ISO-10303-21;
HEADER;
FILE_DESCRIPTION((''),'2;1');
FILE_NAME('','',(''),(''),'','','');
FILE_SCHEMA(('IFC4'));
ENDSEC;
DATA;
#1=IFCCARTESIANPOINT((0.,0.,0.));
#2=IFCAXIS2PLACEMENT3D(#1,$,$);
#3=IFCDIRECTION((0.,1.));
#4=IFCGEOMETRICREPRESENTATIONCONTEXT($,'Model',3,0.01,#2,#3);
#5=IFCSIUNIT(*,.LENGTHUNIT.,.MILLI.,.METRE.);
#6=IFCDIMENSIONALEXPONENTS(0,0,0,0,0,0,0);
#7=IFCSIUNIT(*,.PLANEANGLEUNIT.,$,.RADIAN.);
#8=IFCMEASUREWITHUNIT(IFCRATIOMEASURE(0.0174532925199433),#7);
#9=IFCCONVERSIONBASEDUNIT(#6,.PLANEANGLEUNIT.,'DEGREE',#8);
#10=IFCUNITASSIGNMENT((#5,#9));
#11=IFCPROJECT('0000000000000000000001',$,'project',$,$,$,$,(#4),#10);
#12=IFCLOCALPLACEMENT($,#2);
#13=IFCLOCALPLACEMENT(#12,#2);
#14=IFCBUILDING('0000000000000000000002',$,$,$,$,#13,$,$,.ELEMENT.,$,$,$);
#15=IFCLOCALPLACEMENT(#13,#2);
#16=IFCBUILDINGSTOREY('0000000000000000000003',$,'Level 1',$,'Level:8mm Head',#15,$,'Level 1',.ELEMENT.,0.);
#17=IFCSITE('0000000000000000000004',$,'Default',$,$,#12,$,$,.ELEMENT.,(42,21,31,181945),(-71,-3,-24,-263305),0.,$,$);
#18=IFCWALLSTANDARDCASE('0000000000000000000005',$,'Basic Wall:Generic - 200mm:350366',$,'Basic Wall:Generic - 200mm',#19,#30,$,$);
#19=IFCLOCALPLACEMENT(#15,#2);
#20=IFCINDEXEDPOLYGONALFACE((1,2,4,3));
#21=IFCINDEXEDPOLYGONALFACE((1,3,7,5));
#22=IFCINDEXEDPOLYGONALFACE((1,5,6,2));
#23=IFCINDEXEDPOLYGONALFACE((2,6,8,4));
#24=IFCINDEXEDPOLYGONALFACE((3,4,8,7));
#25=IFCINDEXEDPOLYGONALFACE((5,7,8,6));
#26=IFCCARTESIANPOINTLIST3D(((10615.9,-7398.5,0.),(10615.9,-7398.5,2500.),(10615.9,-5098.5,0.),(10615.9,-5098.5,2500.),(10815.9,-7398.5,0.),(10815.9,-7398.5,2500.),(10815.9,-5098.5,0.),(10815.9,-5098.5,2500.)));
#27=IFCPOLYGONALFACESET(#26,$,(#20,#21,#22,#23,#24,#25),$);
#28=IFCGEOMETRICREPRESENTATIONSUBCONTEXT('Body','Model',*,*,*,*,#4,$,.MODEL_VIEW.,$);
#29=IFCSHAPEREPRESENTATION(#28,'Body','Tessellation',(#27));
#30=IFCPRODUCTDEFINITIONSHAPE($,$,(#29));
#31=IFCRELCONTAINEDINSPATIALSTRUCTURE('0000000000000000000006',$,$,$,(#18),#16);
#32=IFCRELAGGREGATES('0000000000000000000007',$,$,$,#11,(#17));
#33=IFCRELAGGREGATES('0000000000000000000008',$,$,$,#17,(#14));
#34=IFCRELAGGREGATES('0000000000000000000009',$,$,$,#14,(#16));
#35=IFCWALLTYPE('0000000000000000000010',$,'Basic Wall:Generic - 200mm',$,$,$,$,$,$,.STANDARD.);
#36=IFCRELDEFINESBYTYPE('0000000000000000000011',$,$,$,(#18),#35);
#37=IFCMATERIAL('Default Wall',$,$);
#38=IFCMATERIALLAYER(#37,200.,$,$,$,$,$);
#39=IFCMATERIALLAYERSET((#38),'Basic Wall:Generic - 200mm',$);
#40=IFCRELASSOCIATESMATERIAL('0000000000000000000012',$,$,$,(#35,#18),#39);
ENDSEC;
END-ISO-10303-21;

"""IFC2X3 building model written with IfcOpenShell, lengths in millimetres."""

from ifc_helpers import new_model, entity, si_unit, converted_unit, direction, frame, frame_2d, origin, place, context, subcontext, project, spatial, rectangle, extrude, material, layer, layer_set, layer_usage, type_object, element, save


model = new_model("IFC2X3")

# Units and contexts
model_context = context("Model", 3, precision=0.01, world=origin(), true_north=direction((0.0, 1.0)))
body_context = subcontext(model_context, "Body", "Model", "MODEL_VIEW")
ifc_project = project(units=[si_unit("LENGTHUNIT", "METRE", prefix="MILLI"), converted_unit("PLANEANGLEUNIT", "DEGREE", entity("IfcRatioMeasure", 0.0174532925199433), si_unit("PLANEANGLEUNIT", "RADIAN"), dimensions=[0, 0, 0, 0, 0, 0, 0])], contexts=[model_context])

# Site, building, storey
site_placement = place(None, origin())
site = spatial("IfcSite", under=ifc_project, at=site_placement, Name="Default", CompositionType="ELEMENT", RefLatitude=(42, 21, 31, 181945), RefLongitude=(-71, -3, -24, -263305), RefElevation=0.0)
building_placement = place(site_placement, origin())
building = spatial("IfcBuilding", under=site, at=building_placement, CompositionType="ELEMENT")
storey_placement = place(building_placement, origin())
storey = spatial("IfcBuildingStorey", under=building, at=storey_placement, Name="Level 1", ObjectType="Level:8mm Head", LongName="Level 1", CompositionType="ELEMENT", Elevation=0.0)

# Wall
ifc_material_1 = material(Name="Default Wall")
ifc_layer_1 = layer(ifc_material_1, 200.0)
ifc_layer_set_1 = layer_set([ifc_layer_1], Name="Basic Wall:Generic - 200mm")
wall_type = type_object("IfcWallType", Name="Basic Wall:Generic - 200mm", PredefinedType="STANDARD", material=ifc_layer_set_1)
ifc_layer_usage_1 = layer_usage(ifc_layer_set_1, "AXIS2", "NEGATIVE", 100.0)
wall_1_placement = place(storey_placement, frame((10715.9, -7398.5, 0.0), z_axis=(0.0, 0.0, 1.0), x_axis=(0.0, 1.0, 0.0)))
element("IfcWallStandardCase", 1, at=wall_1_placement, inside=storey, type_object=wall_type, material=ifc_layer_usage_1, Name="Basic Wall:Generic - 200mm:350366", ObjectType="Basic Wall:Generic - 200mm", context=body_context, shape_type="SweptSolid", body=[
    extrude(rectangle(XDim=2300.0, YDim=200.0, at=frame_2d((1150.0, 0.0), x_axis=(-1.0, 0.0))), origin(), (0.0, 0.0, 1.0), 2500.0),
])

save(model, "model.ifc")
